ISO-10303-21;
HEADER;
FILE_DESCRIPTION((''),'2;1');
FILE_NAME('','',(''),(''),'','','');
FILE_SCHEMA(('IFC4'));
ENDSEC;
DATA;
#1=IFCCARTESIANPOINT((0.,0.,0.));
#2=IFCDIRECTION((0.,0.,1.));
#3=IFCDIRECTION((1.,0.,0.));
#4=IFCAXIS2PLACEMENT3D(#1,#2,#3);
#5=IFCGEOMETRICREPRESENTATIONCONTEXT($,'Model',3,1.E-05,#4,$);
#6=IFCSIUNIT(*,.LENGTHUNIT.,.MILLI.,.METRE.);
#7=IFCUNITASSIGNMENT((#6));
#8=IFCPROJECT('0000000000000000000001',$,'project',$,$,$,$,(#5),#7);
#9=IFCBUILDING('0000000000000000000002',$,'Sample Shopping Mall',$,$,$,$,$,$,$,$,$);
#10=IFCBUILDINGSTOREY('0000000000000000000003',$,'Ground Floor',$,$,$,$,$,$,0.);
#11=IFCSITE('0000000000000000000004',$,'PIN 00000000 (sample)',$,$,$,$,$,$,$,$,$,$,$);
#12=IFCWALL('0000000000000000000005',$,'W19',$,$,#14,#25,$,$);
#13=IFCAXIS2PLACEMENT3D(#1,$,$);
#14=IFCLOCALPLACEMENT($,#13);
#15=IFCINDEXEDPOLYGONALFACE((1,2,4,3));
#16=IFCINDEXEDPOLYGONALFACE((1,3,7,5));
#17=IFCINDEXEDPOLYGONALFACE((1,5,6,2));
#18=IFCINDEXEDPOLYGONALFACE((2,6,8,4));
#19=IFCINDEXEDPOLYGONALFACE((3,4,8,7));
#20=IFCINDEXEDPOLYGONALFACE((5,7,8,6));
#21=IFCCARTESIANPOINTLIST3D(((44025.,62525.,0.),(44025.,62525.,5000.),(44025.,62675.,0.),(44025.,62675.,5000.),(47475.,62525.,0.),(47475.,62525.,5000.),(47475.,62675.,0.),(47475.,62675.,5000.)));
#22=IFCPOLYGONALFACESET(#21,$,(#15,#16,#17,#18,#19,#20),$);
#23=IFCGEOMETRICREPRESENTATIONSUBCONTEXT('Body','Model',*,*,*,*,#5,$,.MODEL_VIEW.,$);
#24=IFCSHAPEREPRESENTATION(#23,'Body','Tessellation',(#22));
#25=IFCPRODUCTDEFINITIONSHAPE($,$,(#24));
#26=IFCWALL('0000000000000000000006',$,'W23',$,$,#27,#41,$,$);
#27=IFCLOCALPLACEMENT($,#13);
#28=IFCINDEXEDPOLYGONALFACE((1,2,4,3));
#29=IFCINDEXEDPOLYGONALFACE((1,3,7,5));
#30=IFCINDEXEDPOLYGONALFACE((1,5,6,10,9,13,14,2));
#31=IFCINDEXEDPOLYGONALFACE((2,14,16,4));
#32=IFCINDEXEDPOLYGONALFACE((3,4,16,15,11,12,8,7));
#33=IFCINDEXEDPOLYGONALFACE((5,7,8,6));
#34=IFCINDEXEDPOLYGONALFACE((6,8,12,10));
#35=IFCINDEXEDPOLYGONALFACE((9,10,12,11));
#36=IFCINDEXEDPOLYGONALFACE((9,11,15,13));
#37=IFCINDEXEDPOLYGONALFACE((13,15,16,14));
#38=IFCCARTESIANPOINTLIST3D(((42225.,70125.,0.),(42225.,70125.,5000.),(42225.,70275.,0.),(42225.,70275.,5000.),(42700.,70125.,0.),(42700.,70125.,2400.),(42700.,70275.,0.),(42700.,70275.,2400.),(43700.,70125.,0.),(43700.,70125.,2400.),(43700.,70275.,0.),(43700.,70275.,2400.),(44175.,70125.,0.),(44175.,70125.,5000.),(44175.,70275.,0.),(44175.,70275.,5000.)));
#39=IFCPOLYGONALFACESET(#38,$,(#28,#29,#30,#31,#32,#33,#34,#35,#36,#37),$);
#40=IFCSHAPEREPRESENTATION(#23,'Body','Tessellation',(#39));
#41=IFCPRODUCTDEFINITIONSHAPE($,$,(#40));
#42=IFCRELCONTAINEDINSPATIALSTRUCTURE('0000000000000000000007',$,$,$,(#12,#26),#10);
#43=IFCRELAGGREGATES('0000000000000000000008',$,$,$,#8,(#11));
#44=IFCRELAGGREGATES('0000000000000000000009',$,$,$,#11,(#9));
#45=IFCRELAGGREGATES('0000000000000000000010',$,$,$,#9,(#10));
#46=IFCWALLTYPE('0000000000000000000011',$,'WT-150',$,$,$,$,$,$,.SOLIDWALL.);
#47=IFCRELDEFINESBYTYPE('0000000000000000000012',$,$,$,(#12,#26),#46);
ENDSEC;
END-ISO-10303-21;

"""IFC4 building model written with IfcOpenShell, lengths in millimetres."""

from ifc_helpers import new_model, si_unit, frame, origin_with_axes, place, context, subcontext, project, spatial, indexed_curve, outline, extrude, type_object, element, save


model = new_model("IFC4")

# Units and contexts
model_context = context("Model", 3, precision=1e-05, world=origin_with_axes())
body_context = subcontext(model_context, "Body", "Model", "MODEL_VIEW")
ifc_project = project(units=[si_unit("LENGTHUNIT", "METRE", prefix="MILLI")], contexts=[model_context])

# Site, building, storey
site = spatial("IfcSite", under=ifc_project, Name="PIN 00000000 (sample)")
building = spatial("IfcBuilding", under=site, Name="Sample Shopping Mall")
storey = spatial("IfcBuildingStorey", under=building, Name="Ground Floor", Elevation=0.0)

# Wall
wall_type_1 = type_object("IfcWallType", Name="WT-150", PredefinedType="SOLIDWALL")
for number, where, z_axis, x_axis, name in (
    (1, (44025.0, 62525.0, 0.0), (0.0, 0.0, 1.0), (1.0, 0.0, 0.0), "W19"),
):
    element("IfcWall", number, at=place(None, frame(where, z_axis=z_axis, x_axis=x_axis)), inside=storey, type_object=wall_type_1, Name=name, context=body_context, shape_type="SweptSolid", body=[
        extrude(outline(indexed_curve([(0.0, 0.0), (0.0, 150.0), (3450.0, 150.0), (3450.0, 0.0), (0.0, 0.0)], self_intersect=False)), origin_with_axes(), (0.0, 0.0, 1.0), 5000.0),
    ])

# Wall, opening
wall_1_placement = place(None, frame((42225.0, 70125.0, 0.0), z_axis=(0.0, 0.0, 1.0), x_axis=(1.0, 0.0, 0.0)))
wall_1 = element("IfcWall", 2, at=wall_1_placement, inside=storey, type_object=wall_type_1, Name="W23", context=body_context, shape_type="SweptSolid", body=[
    extrude(outline(indexed_curve([(0.0, 0.0), (0.0, 150.0), (1950.0, 150.0), (1950.0, 0.0), (0.0, 0.0)], self_intersect=False)), origin_with_axes(), (0.0, 0.0, 1.0), 5000.0),
])
opening_1_placement = place(wall_1_placement, frame((475.0, -100.0, 0.0), z_axis=(0.0, 0.0, 1.0), x_axis=(1.0, 0.0, 0.0)))
element("IfcOpeningElement", 3, at=opening_1_placement, cuts=wall_1, context=body_context, shape_type="SweptSolid", body=[
    extrude(outline(indexed_curve([(0.0, 0.0), (0.0, 350.0), (1000.0, 350.0), (1000.0, 0.0), (0.0, 0.0)], self_intersect=False)), origin_with_axes(), (0.0, 0.0, 1.0), 2400.0),
])

save(model, "model.ifc")
